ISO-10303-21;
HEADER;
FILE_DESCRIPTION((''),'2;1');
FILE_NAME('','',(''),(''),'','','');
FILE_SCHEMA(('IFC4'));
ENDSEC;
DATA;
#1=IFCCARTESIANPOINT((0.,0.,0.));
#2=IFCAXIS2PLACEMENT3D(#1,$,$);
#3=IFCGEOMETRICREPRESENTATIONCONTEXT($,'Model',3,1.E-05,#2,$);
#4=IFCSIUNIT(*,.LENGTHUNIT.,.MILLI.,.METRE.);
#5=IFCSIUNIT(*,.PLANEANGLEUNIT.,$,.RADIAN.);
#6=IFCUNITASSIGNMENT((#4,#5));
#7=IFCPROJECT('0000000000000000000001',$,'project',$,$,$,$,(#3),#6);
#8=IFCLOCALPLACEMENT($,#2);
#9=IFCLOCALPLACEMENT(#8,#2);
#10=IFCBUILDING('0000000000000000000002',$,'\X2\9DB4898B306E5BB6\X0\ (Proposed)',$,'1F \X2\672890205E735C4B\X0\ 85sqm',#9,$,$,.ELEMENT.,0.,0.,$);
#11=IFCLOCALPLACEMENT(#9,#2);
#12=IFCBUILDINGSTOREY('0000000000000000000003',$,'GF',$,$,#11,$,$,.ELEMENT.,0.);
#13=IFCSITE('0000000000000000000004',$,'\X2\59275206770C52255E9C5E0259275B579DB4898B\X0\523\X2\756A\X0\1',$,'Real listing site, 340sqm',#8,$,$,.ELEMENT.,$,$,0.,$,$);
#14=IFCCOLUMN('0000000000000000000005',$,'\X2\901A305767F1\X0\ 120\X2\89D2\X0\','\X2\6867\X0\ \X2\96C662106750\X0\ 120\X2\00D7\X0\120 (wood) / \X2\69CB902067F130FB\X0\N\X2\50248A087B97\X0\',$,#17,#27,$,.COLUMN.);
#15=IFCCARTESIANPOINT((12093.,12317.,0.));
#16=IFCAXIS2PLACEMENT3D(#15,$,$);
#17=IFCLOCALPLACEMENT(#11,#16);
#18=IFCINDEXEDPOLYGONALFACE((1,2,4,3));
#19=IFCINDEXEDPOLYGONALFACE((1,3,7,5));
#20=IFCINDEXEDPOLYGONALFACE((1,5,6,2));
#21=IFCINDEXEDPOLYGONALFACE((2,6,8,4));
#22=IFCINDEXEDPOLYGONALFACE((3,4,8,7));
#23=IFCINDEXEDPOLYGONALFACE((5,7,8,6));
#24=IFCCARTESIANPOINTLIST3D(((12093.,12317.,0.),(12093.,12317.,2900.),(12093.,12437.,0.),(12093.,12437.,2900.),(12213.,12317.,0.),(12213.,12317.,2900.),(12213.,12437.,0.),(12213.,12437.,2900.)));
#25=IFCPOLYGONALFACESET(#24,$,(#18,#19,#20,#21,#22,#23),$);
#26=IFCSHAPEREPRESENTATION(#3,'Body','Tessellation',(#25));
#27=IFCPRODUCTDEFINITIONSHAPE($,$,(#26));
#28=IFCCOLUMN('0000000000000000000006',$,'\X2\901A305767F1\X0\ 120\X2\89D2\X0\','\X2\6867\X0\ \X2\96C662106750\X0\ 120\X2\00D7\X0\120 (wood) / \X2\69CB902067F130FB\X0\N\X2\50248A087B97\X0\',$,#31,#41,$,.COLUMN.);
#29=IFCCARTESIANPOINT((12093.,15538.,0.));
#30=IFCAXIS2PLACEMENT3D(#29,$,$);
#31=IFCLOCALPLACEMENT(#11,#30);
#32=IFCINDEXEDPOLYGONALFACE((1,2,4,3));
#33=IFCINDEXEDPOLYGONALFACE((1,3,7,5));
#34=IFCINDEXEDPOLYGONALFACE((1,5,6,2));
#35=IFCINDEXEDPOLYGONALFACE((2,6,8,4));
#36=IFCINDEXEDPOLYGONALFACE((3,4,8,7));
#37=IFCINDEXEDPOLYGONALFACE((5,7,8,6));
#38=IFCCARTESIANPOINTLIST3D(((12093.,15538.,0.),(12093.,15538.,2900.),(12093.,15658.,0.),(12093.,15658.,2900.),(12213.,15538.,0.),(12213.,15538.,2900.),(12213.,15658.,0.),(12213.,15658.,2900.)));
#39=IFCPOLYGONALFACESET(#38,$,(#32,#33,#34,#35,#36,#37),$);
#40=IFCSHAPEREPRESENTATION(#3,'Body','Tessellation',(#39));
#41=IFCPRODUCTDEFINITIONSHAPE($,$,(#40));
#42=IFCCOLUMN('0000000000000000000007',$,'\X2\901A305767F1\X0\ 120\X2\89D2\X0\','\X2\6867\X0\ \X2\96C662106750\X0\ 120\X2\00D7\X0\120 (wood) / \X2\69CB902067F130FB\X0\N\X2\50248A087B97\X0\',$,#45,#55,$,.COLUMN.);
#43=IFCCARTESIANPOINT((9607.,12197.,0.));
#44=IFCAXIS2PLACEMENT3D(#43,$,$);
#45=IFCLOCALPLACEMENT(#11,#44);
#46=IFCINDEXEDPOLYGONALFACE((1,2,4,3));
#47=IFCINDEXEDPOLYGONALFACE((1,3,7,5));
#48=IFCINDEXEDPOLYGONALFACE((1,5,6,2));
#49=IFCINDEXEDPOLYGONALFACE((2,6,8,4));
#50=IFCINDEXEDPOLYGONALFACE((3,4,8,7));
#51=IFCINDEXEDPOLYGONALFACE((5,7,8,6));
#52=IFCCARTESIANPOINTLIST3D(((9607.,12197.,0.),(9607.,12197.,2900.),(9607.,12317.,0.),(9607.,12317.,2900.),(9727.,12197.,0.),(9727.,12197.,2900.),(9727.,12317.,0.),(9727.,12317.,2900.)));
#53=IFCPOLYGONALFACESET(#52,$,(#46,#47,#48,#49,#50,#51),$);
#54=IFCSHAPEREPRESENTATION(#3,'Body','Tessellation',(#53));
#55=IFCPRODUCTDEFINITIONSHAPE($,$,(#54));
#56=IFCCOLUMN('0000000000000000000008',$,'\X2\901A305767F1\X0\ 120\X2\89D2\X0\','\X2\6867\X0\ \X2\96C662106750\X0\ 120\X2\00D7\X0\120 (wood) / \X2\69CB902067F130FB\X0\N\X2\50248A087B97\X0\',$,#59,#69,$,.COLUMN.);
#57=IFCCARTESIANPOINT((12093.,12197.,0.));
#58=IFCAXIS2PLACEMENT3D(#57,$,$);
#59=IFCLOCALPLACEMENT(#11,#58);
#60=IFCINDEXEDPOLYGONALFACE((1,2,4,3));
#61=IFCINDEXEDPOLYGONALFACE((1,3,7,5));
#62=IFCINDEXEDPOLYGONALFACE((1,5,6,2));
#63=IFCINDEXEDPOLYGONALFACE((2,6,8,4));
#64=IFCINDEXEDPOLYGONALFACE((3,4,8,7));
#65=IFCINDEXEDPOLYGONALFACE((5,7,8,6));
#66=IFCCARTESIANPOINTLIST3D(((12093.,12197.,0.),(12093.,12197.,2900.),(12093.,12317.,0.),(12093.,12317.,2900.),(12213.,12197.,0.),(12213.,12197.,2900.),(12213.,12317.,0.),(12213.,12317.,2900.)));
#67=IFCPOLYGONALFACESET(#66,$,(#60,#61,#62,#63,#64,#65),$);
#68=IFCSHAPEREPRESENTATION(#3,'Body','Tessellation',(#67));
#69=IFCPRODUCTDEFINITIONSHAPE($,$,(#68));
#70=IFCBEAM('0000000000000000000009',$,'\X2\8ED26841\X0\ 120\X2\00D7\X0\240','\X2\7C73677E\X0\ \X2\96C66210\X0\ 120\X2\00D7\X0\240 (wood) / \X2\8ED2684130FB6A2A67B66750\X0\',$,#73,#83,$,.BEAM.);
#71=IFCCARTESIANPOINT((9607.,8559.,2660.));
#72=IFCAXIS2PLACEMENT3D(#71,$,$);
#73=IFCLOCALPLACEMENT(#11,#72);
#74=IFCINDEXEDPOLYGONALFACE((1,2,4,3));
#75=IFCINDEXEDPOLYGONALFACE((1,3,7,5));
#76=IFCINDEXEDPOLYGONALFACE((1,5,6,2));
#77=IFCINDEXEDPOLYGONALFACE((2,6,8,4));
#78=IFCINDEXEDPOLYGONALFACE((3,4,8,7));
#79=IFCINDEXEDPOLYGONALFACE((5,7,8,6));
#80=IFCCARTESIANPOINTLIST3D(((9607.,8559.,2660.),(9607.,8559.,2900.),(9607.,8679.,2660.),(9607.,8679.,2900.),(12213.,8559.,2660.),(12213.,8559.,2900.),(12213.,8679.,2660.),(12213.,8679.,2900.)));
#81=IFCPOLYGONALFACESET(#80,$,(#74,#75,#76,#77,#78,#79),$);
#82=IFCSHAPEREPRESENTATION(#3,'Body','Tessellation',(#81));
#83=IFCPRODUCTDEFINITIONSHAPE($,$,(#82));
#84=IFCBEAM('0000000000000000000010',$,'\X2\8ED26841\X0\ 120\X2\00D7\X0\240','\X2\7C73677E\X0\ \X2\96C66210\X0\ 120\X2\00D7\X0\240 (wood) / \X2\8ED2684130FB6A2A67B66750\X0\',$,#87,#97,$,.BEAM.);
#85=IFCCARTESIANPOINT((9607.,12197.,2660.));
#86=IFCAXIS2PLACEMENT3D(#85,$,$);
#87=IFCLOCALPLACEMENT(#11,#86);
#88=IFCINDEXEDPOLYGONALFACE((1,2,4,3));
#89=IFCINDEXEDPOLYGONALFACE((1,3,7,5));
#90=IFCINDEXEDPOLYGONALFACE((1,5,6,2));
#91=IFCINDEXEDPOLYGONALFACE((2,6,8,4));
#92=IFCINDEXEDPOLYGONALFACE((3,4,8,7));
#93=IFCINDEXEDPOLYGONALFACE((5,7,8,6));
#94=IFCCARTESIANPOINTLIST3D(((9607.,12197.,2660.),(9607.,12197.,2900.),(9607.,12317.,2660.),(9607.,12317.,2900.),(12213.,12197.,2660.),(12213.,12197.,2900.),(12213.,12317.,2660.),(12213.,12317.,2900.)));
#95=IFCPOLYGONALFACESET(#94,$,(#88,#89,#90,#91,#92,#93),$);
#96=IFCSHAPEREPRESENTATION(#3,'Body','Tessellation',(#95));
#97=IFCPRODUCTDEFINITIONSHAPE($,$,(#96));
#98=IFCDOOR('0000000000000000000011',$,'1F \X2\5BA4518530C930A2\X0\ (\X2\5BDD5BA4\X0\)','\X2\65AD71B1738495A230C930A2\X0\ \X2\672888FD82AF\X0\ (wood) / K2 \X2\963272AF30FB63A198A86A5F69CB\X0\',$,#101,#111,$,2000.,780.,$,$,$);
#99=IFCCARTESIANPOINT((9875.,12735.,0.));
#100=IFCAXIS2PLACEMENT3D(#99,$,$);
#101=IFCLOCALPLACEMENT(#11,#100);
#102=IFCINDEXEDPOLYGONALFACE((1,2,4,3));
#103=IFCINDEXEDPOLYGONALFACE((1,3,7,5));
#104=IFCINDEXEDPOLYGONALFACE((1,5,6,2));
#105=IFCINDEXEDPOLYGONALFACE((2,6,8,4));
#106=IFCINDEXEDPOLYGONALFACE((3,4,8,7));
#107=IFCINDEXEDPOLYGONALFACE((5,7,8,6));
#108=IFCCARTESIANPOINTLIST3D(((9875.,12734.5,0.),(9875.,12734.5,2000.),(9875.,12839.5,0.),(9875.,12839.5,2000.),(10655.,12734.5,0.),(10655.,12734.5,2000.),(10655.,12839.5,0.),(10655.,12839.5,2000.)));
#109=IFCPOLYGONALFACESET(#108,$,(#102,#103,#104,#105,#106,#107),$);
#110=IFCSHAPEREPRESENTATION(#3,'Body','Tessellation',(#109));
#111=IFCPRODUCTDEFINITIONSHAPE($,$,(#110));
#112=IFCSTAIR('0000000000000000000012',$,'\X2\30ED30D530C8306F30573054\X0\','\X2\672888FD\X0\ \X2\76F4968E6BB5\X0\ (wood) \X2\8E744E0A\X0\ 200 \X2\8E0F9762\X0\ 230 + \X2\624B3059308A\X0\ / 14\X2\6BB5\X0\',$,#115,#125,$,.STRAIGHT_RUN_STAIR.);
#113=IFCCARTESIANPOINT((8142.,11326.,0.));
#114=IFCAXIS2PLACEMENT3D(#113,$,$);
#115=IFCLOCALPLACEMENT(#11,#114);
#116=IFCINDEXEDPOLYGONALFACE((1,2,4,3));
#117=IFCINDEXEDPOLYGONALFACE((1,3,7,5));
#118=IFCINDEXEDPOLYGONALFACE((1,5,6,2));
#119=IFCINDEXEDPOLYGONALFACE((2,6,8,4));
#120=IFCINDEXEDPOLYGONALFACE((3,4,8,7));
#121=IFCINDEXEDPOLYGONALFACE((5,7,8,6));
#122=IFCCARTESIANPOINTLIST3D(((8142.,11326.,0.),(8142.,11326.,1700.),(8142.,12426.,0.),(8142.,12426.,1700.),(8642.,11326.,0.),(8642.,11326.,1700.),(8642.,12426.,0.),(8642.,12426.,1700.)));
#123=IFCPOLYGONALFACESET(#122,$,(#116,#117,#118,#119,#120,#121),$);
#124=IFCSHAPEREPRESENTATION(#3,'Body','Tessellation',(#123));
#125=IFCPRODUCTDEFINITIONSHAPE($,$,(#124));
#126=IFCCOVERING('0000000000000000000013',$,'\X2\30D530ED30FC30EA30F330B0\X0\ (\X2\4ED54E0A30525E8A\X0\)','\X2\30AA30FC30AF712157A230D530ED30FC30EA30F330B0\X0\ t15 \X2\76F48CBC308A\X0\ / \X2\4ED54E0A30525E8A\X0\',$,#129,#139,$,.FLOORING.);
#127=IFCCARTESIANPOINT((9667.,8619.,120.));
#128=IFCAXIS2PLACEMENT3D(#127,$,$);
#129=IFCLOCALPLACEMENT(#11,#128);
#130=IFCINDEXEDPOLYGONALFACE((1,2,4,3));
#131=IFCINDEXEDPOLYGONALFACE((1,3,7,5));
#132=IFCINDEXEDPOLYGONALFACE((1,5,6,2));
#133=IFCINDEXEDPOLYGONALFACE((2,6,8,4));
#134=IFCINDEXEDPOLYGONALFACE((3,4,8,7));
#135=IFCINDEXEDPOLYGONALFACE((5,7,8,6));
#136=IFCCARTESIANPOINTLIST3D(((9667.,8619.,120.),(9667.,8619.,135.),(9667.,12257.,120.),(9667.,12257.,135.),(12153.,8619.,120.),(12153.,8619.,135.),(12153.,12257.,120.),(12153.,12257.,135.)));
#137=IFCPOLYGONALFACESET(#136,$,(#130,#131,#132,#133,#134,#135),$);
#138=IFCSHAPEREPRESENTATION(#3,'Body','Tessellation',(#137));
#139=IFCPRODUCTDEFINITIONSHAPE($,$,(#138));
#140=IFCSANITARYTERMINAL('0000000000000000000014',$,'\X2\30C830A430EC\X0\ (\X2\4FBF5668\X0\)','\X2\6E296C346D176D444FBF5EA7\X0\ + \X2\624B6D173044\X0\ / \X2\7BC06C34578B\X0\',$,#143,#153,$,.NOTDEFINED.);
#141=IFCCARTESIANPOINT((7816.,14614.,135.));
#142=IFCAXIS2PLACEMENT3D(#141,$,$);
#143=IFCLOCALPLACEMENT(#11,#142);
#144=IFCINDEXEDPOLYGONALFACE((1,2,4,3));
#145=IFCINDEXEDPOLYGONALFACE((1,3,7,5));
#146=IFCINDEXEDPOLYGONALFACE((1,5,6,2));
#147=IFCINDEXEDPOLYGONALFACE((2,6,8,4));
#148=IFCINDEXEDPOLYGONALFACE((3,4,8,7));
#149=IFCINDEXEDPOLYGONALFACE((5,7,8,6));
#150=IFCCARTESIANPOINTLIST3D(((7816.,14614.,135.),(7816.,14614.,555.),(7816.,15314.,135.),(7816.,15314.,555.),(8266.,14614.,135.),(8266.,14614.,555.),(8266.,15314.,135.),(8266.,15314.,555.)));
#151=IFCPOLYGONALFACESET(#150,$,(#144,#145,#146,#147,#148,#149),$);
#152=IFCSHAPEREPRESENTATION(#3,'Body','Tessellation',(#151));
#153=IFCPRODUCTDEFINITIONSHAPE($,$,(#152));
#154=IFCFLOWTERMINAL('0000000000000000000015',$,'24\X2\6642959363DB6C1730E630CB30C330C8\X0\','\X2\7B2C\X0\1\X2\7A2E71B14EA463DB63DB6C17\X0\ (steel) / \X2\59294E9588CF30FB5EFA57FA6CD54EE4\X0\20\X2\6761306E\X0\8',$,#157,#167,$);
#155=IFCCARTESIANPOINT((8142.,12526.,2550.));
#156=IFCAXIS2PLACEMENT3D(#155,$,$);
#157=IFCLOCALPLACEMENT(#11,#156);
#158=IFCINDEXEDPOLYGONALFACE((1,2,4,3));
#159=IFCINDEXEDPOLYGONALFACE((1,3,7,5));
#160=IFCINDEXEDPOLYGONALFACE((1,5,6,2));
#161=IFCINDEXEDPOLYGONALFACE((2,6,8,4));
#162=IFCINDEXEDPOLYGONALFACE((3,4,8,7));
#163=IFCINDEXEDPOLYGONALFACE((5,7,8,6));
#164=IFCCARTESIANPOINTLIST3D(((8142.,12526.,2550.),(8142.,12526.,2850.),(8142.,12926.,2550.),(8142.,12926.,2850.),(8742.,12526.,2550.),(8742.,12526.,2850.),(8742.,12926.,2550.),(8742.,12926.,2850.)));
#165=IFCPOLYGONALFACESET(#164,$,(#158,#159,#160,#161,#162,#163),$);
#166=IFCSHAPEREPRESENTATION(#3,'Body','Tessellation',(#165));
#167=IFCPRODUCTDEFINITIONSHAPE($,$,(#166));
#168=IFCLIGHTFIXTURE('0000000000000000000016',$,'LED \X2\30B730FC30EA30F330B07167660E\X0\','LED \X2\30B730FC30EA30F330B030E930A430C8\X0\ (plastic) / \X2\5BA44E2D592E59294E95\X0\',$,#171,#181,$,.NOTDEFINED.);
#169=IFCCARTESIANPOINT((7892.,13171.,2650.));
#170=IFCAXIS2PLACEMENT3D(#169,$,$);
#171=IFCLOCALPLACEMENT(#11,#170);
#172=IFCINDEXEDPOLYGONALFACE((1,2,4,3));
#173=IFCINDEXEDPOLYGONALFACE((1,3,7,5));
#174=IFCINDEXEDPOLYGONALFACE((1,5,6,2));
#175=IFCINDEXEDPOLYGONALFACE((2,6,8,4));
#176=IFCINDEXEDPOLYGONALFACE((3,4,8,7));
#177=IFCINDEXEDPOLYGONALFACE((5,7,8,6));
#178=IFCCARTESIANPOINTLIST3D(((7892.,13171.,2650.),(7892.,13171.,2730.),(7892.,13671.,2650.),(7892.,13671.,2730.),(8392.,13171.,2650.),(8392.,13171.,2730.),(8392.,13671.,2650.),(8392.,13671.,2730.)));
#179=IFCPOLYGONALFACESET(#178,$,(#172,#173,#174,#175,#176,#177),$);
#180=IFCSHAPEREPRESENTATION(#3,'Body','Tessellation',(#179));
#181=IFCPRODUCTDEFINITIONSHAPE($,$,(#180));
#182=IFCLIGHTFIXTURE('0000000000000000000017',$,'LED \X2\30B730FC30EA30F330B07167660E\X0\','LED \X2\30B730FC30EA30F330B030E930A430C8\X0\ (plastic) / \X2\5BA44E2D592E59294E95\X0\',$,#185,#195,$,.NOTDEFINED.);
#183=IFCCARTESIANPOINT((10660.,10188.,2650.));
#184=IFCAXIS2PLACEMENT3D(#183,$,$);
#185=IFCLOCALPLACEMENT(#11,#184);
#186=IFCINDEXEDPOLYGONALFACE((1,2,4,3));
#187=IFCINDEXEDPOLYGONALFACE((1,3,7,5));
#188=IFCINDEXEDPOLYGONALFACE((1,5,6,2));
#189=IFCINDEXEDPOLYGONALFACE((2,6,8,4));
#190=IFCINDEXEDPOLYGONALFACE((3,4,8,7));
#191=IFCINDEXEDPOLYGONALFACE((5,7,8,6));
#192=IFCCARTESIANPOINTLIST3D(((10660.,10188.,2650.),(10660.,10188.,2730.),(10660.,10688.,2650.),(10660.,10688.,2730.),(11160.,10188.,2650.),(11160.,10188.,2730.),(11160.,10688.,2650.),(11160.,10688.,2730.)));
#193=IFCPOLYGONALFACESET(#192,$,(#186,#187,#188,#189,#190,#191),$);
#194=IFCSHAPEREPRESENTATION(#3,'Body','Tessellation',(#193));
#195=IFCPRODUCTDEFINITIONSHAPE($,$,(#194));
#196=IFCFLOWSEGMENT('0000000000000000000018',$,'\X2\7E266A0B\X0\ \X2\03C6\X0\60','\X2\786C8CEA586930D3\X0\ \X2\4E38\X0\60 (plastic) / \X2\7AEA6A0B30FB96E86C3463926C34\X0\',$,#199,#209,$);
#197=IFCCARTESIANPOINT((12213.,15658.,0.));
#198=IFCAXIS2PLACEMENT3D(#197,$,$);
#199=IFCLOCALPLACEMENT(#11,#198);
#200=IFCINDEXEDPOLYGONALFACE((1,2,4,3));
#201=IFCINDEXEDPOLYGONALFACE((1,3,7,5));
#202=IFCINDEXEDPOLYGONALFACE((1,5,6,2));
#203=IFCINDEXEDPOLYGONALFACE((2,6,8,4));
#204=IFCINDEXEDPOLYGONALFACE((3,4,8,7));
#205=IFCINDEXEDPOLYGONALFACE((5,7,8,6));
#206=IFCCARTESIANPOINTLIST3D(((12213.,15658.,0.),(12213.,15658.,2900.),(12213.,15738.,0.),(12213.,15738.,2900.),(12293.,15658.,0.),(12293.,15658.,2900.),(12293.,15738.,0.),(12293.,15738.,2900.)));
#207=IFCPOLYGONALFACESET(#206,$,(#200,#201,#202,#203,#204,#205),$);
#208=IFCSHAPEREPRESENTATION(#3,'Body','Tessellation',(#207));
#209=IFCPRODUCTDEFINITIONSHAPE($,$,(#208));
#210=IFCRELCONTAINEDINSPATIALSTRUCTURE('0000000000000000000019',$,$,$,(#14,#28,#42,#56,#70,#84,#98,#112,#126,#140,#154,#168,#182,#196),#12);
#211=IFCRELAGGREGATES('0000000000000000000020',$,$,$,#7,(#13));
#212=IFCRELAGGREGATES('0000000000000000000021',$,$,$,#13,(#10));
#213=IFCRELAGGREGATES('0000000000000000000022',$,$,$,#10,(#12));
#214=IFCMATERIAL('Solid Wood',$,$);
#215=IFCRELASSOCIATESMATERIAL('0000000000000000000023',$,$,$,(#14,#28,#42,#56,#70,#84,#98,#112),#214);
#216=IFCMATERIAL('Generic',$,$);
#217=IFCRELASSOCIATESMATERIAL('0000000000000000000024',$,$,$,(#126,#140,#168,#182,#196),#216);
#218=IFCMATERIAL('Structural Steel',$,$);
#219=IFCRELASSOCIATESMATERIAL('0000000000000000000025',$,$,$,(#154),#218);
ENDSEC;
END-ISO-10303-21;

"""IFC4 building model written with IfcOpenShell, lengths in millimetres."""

from ifc_helpers import new_model, si_unit, frame, frame_2d, origin, place, context, project, spatial, rectangle, extrude, material, element, save


model = new_model("IFC4")

# Units and contexts
model_context = context("Model", 3, precision=1e-05, world=origin())
ifc_project = project(units=[si_unit("LENGTHUNIT", "METRE", prefix="MILLI"), si_unit("PLANEANGLEUNIT", "RADIAN")], contexts=[model_context])

# Site, building, storey
site_placement = place(None, origin())
site = spatial("IfcSite", under=ifc_project, at=site_placement, Name="大分県別府市大字鶴見523番1", ObjectType="Real listing site, 340sqm", CompositionType="ELEMENT", RefElevation=0.0)
building_placement = place(site_placement, origin())
building = spatial("IfcBuilding", under=site, at=building_placement, Name="鶴見の家 (Proposed)", ObjectType="1F 木造平屋 85sqm", CompositionType="ELEMENT", ElevationOfRefHeight=0.0, ElevationOfTerrain=0.0)
storey_placement = place(building_placement, origin())
storey = spatial("IfcBuildingStorey", under=building, at=storey_placement, Name="GF", CompositionType="ELEMENT", Elevation=0.0)

# Columns
ifc_material_1 = material(Name="Solid Wood")
column_1_placement = place(storey_placement, frame((12093.0, 12317.0, 0.0)))
element("IfcColumn", 1, at=column_1_placement, inside=storey, material=ifc_material_1, Name="通し柱 120角", Description="桧 集成材 120×120 (wood) / 構造柱・N値計算", PredefinedType="COLUMN", context=model_context, shape_type="SweptSolid", body=[
    extrude(rectangle(XDim=120.0, YDim=120.0, at=frame_2d((60.0, 60.0))), frame((12093.0, 12317.0, 0.0)), (0.0, 0.0, 1.0), 2900.0),
])
column_2_placement = place(storey_placement, frame((12093.0, 15538.0, 0.0)))
element("IfcColumn", 2, at=column_2_placement, inside=storey, material=ifc_material_1, Name="通し柱 120角", Description="桧 集成材 120×120 (wood) / 構造柱・N値計算", PredefinedType="COLUMN", context=model_context, shape_type="SweptSolid", body=[
    extrude(rectangle(XDim=120.0, YDim=120.0, at=frame_2d((60.0, 60.0))), frame((12093.0, 15538.0, 0.0)), (0.0, 0.0, 1.0), 2900.0),
])
column_3_placement = place(storey_placement, frame((9607.0, 12197.0, 0.0)))
element("IfcColumn", 3, at=column_3_placement, inside=storey, material=ifc_material_1, Name="通し柱 120角", Description="桧 集成材 120×120 (wood) / 構造柱・N値計算", PredefinedType="COLUMN", context=model_context, shape_type="SweptSolid", body=[
    extrude(rectangle(XDim=120.0, YDim=120.0, at=frame_2d((60.0, 60.0))), frame((9607.0, 12197.0, 0.0)), (0.0, 0.0, 1.0), 2900.0),
])
column_4_placement = place(storey_placement, frame((12093.0, 12197.0, 0.0)))
element("IfcColumn", 4, at=column_4_placement, inside=storey, material=ifc_material_1, Name="通し柱 120角", Description="桧 集成材 120×120 (wood) / 構造柱・N値計算", PredefinedType="COLUMN", context=model_context, shape_type="SweptSolid", body=[
    extrude(rectangle(XDim=120.0, YDim=120.0, at=frame_2d((60.0, 60.0))), frame((12093.0, 12197.0, 0.0)), (0.0, 0.0, 1.0), 2900.0),
])

# Beams
beam_1_placement = place(storey_placement, frame((9607.0, 8559.0, 2660.0)))
element("IfcBeam", 5, at=beam_1_placement, inside=storey, material=ifc_material_1, Name="軒桁 120×240", Description="米松 集成 120×240 (wood) / 軒桁・横架材", PredefinedType="BEAM", context=model_context, shape_type="SweptSolid", body=[
    extrude(rectangle(XDim=2606.0, YDim=120.0, at=frame_2d((1303.0, 60.0))), frame((9607.0, 8559.0, 2660.0)), (0.0, 0.0, 1.0), 240.0),
])
beam_2_placement = place(storey_placement, frame((9607.0, 12197.0, 2660.0)))
element("IfcBeam", 6, at=beam_2_placement, inside=storey, material=ifc_material_1, Name="軒桁 120×240", Description="米松 集成 120×240 (wood) / 軒桁・横架材", PredefinedType="BEAM", context=model_context, shape_type="SweptSolid", body=[
    extrude(rectangle(XDim=2606.0, YDim=120.0, at=frame_2d((1303.0, 60.0))), frame((9607.0, 12197.0, 2660.0)), (0.0, 0.0, 1.0), 240.0),
])

# Door
door_placement = place(storey_placement, frame((9875.0, 12735.0, 0.0)))
element("IfcDoor", 7, at=door_placement, inside=storey, material=ifc_material_1, Name="1F 室内ドア (寝室)", Description="断熱玄関ドア 木製芯 (wood) / K2 防犯・採風機構", OverallHeight=2000.0, OverallWidth=780.0, context=model_context, shape_type="SweptSolid", body=[
    extrude(rectangle(XDim=780.0, YDim=105.0, at=frame_2d((390.0, 52.0))), frame((9875.0, 12735.0, 0.0)), (0.0, 0.0, 1.0), 2000.0),
])

# Stair
stair_placement = place(storey_placement, frame((8142.0, 11326.0, 0.0)))
element("IfcStair", 8, at=stair_placement, inside=storey, material=ifc_material_1, Name="ロフトはしご", Description="木製 直階段 (wood) 蹴上 200 踏面 230 + 手すり / 14段", PredefinedType="STRAIGHT_RUN_STAIR", context=model_context, shape_type="SweptSolid", body=[
    extrude(rectangle(XDim=500.0, YDim=1100.0, at=frame_2d((250.0, 550.0))), frame((8142.0, 11326.0, 0.0)), (0.0, 0.0, 1.0), 1700.0),
])

# Covering
ifc_material_2 = material(Name="Generic")
covering_placement = place(storey_placement, frame((9667.0, 8619.0, 120.0)))
element("IfcCovering", 9, at=covering_placement, inside=storey, material=ifc_material_2, Name="フローリング (仕上げ床)", Description="オーク無垢フローリング t15 直貼り / 仕上げ床", PredefinedType="FLOORING", context=model_context, shape_type="SweptSolid", body=[
    extrude(rectangle(XDim=2486.0, YDim=3638.0, at=frame_2d((1243.0, 1819.0))), frame((9667.0, 8619.0, 120.0)), (0.0, 0.0, 1.0), 15.0),
])

# Sanitary terminal
sanitary_terminal_placement = place(storey_placement, frame((7816.0, 14614.0, 135.0)))
element("IfcSanitaryTerminal", 10, at=sanitary_terminal_placement, inside=storey, material=ifc_material_2, Name="トイレ (便器)", Description="温水洗浄便座 + 手洗い / 節水型", PredefinedType="NOTDEFINED", context=model_context, shape_type="SweptSolid", body=[
    extrude(rectangle(XDim=450.0, YDim=700.0, at=frame_2d((225.0, 350.0))), frame((7816.0, 14614.0, 135.0)), (0.0, 0.0, 1.0), 420.0),
])

# Flow terminal
ifc_material_3 = material(Name="Structural Steel")
flow_terminal_placement = place(storey_placement, frame((8142.0, 12526.0, 2550.0)))
element("IfcFlowTerminal", 11, at=flow_terminal_placement, inside=storey, material=ifc_material_3, Name="24時間換気ユニット", Description="第1種熱交換換気 (steel) / 天井裏・建基法令20条の8", context=model_context, shape_type="SweptSolid", body=[
    extrude(rectangle(XDim=600.0, YDim=400.0, at=frame_2d((300.0, 200.0))), frame((8142.0, 12526.0, 2550.0)), (0.0, 0.0, 1.0), 300.0),
])

# Light fixtures
light_fixture_1_placement = place(storey_placement, frame((7892.0, 13171.0, 2650.0)))
element("IfcLightFixture", 12, at=light_fixture_1_placement, inside=storey, material=ifc_material_2, Name="LED シーリング照明", Description="LED シーリングライト (plastic) / 室中央天井", PredefinedType="NOTDEFINED", context=model_context, shape_type="SweptSolid", body=[
    extrude(rectangle(XDim=500.0, YDim=500.0, at=frame_2d((250.0, 250.0))), frame((7892.0, 13171.0, 2650.0)), (0.0, 0.0, 1.0), 80.0),
])
light_fixture_2_placement = place(storey_placement, frame((10660.0, 10188.0, 2650.0)))
element("IfcLightFixture", 13, at=light_fixture_2_placement, inside=storey, material=ifc_material_2, Name="LED シーリング照明", Description="LED シーリングライト (plastic) / 室中央天井", PredefinedType="NOTDEFINED", context=model_context, shape_type="SweptSolid", body=[
    extrude(rectangle(XDim=500.0, YDim=500.0, at=frame_2d((250.0, 250.0))), frame((10660.0, 10188.0, 2650.0)), (0.0, 0.0, 1.0), 80.0),
])

# Flow segment
flow_segment_placement = place(storey_placement, frame((12213.0, 15658.0, 0.0)))
element("IfcFlowSegment", 14, at=flow_segment_placement, inside=storey, material=ifc_material_2, Name="縦樋 φ60", Description="硬質塩ビ 丸60 (plastic) / 竪樋・雨水排水", context=model_context, shape_type="SweptSolid", body=[
    extrude(rectangle(XDim=80.0, YDim=80.0, at=frame_2d((40.0, 40.0))), frame((12213.0, 15658.0, 0.0)), (0.0, 0.0, 1.0), 2900.0),
])

save(model, "model.ifc")
